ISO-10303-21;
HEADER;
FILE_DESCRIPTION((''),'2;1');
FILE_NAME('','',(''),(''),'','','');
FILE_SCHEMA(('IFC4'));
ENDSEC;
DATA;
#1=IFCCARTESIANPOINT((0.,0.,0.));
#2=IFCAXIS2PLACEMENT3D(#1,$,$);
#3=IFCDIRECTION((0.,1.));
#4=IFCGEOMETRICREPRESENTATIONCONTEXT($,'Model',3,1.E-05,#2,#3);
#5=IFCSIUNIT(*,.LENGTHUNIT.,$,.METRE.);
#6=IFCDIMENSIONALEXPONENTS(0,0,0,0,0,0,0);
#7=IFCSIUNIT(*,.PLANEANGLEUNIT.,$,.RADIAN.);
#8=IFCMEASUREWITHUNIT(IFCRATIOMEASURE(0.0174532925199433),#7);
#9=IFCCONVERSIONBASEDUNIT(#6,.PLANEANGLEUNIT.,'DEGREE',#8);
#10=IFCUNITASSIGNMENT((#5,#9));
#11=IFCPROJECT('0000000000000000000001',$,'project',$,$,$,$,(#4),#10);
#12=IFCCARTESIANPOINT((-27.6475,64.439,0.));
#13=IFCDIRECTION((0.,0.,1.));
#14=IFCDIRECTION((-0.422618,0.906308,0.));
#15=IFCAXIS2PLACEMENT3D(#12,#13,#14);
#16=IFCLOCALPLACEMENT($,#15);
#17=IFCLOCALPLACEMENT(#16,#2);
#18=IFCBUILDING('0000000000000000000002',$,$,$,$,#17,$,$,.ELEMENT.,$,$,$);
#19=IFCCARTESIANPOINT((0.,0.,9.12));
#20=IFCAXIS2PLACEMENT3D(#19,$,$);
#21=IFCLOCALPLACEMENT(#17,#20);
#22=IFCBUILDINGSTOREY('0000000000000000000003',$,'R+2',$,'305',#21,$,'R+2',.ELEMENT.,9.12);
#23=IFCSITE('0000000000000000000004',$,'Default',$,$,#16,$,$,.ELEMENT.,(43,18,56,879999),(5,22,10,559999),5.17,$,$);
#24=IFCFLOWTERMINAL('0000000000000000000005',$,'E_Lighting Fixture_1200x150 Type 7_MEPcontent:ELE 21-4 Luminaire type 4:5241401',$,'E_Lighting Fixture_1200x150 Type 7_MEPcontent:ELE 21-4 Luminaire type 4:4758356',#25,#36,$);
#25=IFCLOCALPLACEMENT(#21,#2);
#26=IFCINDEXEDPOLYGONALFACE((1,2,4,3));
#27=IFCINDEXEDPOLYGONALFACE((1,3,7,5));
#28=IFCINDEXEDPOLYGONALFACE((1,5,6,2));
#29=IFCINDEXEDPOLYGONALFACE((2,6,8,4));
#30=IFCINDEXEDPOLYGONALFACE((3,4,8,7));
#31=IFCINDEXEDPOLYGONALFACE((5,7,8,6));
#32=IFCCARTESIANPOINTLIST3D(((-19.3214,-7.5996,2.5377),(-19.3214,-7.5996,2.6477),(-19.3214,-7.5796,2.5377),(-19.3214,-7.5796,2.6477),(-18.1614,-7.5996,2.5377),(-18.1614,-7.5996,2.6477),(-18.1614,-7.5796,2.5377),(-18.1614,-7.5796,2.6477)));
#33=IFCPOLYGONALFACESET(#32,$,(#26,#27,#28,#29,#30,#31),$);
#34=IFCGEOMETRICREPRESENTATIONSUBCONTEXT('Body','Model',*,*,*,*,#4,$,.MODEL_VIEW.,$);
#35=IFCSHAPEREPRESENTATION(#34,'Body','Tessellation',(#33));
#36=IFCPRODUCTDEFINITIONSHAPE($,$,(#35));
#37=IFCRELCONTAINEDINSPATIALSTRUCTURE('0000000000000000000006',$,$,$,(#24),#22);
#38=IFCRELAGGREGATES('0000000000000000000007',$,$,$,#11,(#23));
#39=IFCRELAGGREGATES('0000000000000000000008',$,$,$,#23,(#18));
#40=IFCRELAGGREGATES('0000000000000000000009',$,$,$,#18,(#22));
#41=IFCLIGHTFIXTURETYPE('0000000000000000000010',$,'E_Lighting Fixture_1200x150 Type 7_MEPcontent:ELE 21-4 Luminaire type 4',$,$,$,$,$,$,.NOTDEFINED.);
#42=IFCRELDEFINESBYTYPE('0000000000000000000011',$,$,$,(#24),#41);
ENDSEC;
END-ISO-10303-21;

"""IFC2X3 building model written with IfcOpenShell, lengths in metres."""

from ifc_helpers import new_model, entity, si_unit, converted_unit, direction, frame, frame_2d, origin, place, context, subcontext, project, spatial, rectangle, extrude, source, transform, mapped, type_object, type_shapes, element, save


model = new_model("IFC2X3")

# Units and contexts
model_context = context("Model", 3, precision=1e-05, world=origin(), true_north=direction((0.0, 1.0)))
body_context = subcontext(model_context, "Body", "Model", "MODEL_VIEW")
ifc_project = project(units=[si_unit("LENGTHUNIT", "METRE"), converted_unit("PLANEANGLEUNIT", "DEGREE", entity("IfcRatioMeasure", 0.0174532925199433), si_unit("PLANEANGLEUNIT", "RADIAN"), dimensions=[0, 0, 0, 0, 0, 0, 0])], contexts=[model_context])

# Site, building, storey
site_placement = place(None, frame((-27.6475, 64.439, 0.0), z_axis=(0.0, 0.0, 1.0), x_axis=(-0.422618, 0.906308, 0.0)))
site = spatial("IfcSite", under=ifc_project, at=site_placement, Name="Default", CompositionType="ELEMENT", RefLatitude=(43, 18, 56, 879999), RefLongitude=(5, 22, 10, 559999), RefElevation=5.17)
building_placement = place(site_placement, origin())
building = spatial("IfcBuilding", under=site, at=building_placement, CompositionType="ELEMENT")
storey_placement = place(building_placement, frame((0.0, 0.0, 9.12)))
storey = spatial("IfcBuildingStorey", under=building, at=storey_placement, Name="R+2", ObjectType="305", LongName="R+2", CompositionType="ELEMENT", Elevation=9.12)

# Flow terminal
light_fixture_type_1 = type_object("IfcLightFixtureType", Name="E_Lighting Fixture_1200x150 Type 7_MEPcontent:ELE 21-4 Luminaire type 4", PredefinedType="NOTDEFINED")
shared_shape_1 = source(origin(), body_context, "Body", "SweptSolid", [
    extrude(rectangle(XDim=0.02, YDim=1.16, at=frame_2d((0.0, 0.0), x_axis=(1.0, 0.0))), frame((0.0, 0.01, -0.055), z_axis=(0.0, 0.0, 1.0), x_axis=(0.0, -1.0, 0.0)), (0.0, 0.0, 1.0), 0.11),
])
type_shapes(light_fixture_type_1, [shared_shape_1])
flow_terminal_1_placement = place(storey_placement, frame((-18.7414, -7.5996, 2.5927)))
element("IfcFlowTerminal", 1, at=flow_terminal_1_placement, inside=storey, type_object=light_fixture_type_1, Name="E_Lighting Fixture_1200x150 Type 7_MEPcontent:ELE 21-4 Luminaire type 4:5241401", ObjectType="E_Lighting Fixture_1200x150 Type 7_MEPcontent:ELE 21-4 Luminaire type 4:4758356", context=body_context, shape_type="MappedRepresentation", body=[
    mapped(shared_shape_1, transform((0.0, 0.0, 0.0), scale=1.0)),
])

save(model, "model.ifc")
